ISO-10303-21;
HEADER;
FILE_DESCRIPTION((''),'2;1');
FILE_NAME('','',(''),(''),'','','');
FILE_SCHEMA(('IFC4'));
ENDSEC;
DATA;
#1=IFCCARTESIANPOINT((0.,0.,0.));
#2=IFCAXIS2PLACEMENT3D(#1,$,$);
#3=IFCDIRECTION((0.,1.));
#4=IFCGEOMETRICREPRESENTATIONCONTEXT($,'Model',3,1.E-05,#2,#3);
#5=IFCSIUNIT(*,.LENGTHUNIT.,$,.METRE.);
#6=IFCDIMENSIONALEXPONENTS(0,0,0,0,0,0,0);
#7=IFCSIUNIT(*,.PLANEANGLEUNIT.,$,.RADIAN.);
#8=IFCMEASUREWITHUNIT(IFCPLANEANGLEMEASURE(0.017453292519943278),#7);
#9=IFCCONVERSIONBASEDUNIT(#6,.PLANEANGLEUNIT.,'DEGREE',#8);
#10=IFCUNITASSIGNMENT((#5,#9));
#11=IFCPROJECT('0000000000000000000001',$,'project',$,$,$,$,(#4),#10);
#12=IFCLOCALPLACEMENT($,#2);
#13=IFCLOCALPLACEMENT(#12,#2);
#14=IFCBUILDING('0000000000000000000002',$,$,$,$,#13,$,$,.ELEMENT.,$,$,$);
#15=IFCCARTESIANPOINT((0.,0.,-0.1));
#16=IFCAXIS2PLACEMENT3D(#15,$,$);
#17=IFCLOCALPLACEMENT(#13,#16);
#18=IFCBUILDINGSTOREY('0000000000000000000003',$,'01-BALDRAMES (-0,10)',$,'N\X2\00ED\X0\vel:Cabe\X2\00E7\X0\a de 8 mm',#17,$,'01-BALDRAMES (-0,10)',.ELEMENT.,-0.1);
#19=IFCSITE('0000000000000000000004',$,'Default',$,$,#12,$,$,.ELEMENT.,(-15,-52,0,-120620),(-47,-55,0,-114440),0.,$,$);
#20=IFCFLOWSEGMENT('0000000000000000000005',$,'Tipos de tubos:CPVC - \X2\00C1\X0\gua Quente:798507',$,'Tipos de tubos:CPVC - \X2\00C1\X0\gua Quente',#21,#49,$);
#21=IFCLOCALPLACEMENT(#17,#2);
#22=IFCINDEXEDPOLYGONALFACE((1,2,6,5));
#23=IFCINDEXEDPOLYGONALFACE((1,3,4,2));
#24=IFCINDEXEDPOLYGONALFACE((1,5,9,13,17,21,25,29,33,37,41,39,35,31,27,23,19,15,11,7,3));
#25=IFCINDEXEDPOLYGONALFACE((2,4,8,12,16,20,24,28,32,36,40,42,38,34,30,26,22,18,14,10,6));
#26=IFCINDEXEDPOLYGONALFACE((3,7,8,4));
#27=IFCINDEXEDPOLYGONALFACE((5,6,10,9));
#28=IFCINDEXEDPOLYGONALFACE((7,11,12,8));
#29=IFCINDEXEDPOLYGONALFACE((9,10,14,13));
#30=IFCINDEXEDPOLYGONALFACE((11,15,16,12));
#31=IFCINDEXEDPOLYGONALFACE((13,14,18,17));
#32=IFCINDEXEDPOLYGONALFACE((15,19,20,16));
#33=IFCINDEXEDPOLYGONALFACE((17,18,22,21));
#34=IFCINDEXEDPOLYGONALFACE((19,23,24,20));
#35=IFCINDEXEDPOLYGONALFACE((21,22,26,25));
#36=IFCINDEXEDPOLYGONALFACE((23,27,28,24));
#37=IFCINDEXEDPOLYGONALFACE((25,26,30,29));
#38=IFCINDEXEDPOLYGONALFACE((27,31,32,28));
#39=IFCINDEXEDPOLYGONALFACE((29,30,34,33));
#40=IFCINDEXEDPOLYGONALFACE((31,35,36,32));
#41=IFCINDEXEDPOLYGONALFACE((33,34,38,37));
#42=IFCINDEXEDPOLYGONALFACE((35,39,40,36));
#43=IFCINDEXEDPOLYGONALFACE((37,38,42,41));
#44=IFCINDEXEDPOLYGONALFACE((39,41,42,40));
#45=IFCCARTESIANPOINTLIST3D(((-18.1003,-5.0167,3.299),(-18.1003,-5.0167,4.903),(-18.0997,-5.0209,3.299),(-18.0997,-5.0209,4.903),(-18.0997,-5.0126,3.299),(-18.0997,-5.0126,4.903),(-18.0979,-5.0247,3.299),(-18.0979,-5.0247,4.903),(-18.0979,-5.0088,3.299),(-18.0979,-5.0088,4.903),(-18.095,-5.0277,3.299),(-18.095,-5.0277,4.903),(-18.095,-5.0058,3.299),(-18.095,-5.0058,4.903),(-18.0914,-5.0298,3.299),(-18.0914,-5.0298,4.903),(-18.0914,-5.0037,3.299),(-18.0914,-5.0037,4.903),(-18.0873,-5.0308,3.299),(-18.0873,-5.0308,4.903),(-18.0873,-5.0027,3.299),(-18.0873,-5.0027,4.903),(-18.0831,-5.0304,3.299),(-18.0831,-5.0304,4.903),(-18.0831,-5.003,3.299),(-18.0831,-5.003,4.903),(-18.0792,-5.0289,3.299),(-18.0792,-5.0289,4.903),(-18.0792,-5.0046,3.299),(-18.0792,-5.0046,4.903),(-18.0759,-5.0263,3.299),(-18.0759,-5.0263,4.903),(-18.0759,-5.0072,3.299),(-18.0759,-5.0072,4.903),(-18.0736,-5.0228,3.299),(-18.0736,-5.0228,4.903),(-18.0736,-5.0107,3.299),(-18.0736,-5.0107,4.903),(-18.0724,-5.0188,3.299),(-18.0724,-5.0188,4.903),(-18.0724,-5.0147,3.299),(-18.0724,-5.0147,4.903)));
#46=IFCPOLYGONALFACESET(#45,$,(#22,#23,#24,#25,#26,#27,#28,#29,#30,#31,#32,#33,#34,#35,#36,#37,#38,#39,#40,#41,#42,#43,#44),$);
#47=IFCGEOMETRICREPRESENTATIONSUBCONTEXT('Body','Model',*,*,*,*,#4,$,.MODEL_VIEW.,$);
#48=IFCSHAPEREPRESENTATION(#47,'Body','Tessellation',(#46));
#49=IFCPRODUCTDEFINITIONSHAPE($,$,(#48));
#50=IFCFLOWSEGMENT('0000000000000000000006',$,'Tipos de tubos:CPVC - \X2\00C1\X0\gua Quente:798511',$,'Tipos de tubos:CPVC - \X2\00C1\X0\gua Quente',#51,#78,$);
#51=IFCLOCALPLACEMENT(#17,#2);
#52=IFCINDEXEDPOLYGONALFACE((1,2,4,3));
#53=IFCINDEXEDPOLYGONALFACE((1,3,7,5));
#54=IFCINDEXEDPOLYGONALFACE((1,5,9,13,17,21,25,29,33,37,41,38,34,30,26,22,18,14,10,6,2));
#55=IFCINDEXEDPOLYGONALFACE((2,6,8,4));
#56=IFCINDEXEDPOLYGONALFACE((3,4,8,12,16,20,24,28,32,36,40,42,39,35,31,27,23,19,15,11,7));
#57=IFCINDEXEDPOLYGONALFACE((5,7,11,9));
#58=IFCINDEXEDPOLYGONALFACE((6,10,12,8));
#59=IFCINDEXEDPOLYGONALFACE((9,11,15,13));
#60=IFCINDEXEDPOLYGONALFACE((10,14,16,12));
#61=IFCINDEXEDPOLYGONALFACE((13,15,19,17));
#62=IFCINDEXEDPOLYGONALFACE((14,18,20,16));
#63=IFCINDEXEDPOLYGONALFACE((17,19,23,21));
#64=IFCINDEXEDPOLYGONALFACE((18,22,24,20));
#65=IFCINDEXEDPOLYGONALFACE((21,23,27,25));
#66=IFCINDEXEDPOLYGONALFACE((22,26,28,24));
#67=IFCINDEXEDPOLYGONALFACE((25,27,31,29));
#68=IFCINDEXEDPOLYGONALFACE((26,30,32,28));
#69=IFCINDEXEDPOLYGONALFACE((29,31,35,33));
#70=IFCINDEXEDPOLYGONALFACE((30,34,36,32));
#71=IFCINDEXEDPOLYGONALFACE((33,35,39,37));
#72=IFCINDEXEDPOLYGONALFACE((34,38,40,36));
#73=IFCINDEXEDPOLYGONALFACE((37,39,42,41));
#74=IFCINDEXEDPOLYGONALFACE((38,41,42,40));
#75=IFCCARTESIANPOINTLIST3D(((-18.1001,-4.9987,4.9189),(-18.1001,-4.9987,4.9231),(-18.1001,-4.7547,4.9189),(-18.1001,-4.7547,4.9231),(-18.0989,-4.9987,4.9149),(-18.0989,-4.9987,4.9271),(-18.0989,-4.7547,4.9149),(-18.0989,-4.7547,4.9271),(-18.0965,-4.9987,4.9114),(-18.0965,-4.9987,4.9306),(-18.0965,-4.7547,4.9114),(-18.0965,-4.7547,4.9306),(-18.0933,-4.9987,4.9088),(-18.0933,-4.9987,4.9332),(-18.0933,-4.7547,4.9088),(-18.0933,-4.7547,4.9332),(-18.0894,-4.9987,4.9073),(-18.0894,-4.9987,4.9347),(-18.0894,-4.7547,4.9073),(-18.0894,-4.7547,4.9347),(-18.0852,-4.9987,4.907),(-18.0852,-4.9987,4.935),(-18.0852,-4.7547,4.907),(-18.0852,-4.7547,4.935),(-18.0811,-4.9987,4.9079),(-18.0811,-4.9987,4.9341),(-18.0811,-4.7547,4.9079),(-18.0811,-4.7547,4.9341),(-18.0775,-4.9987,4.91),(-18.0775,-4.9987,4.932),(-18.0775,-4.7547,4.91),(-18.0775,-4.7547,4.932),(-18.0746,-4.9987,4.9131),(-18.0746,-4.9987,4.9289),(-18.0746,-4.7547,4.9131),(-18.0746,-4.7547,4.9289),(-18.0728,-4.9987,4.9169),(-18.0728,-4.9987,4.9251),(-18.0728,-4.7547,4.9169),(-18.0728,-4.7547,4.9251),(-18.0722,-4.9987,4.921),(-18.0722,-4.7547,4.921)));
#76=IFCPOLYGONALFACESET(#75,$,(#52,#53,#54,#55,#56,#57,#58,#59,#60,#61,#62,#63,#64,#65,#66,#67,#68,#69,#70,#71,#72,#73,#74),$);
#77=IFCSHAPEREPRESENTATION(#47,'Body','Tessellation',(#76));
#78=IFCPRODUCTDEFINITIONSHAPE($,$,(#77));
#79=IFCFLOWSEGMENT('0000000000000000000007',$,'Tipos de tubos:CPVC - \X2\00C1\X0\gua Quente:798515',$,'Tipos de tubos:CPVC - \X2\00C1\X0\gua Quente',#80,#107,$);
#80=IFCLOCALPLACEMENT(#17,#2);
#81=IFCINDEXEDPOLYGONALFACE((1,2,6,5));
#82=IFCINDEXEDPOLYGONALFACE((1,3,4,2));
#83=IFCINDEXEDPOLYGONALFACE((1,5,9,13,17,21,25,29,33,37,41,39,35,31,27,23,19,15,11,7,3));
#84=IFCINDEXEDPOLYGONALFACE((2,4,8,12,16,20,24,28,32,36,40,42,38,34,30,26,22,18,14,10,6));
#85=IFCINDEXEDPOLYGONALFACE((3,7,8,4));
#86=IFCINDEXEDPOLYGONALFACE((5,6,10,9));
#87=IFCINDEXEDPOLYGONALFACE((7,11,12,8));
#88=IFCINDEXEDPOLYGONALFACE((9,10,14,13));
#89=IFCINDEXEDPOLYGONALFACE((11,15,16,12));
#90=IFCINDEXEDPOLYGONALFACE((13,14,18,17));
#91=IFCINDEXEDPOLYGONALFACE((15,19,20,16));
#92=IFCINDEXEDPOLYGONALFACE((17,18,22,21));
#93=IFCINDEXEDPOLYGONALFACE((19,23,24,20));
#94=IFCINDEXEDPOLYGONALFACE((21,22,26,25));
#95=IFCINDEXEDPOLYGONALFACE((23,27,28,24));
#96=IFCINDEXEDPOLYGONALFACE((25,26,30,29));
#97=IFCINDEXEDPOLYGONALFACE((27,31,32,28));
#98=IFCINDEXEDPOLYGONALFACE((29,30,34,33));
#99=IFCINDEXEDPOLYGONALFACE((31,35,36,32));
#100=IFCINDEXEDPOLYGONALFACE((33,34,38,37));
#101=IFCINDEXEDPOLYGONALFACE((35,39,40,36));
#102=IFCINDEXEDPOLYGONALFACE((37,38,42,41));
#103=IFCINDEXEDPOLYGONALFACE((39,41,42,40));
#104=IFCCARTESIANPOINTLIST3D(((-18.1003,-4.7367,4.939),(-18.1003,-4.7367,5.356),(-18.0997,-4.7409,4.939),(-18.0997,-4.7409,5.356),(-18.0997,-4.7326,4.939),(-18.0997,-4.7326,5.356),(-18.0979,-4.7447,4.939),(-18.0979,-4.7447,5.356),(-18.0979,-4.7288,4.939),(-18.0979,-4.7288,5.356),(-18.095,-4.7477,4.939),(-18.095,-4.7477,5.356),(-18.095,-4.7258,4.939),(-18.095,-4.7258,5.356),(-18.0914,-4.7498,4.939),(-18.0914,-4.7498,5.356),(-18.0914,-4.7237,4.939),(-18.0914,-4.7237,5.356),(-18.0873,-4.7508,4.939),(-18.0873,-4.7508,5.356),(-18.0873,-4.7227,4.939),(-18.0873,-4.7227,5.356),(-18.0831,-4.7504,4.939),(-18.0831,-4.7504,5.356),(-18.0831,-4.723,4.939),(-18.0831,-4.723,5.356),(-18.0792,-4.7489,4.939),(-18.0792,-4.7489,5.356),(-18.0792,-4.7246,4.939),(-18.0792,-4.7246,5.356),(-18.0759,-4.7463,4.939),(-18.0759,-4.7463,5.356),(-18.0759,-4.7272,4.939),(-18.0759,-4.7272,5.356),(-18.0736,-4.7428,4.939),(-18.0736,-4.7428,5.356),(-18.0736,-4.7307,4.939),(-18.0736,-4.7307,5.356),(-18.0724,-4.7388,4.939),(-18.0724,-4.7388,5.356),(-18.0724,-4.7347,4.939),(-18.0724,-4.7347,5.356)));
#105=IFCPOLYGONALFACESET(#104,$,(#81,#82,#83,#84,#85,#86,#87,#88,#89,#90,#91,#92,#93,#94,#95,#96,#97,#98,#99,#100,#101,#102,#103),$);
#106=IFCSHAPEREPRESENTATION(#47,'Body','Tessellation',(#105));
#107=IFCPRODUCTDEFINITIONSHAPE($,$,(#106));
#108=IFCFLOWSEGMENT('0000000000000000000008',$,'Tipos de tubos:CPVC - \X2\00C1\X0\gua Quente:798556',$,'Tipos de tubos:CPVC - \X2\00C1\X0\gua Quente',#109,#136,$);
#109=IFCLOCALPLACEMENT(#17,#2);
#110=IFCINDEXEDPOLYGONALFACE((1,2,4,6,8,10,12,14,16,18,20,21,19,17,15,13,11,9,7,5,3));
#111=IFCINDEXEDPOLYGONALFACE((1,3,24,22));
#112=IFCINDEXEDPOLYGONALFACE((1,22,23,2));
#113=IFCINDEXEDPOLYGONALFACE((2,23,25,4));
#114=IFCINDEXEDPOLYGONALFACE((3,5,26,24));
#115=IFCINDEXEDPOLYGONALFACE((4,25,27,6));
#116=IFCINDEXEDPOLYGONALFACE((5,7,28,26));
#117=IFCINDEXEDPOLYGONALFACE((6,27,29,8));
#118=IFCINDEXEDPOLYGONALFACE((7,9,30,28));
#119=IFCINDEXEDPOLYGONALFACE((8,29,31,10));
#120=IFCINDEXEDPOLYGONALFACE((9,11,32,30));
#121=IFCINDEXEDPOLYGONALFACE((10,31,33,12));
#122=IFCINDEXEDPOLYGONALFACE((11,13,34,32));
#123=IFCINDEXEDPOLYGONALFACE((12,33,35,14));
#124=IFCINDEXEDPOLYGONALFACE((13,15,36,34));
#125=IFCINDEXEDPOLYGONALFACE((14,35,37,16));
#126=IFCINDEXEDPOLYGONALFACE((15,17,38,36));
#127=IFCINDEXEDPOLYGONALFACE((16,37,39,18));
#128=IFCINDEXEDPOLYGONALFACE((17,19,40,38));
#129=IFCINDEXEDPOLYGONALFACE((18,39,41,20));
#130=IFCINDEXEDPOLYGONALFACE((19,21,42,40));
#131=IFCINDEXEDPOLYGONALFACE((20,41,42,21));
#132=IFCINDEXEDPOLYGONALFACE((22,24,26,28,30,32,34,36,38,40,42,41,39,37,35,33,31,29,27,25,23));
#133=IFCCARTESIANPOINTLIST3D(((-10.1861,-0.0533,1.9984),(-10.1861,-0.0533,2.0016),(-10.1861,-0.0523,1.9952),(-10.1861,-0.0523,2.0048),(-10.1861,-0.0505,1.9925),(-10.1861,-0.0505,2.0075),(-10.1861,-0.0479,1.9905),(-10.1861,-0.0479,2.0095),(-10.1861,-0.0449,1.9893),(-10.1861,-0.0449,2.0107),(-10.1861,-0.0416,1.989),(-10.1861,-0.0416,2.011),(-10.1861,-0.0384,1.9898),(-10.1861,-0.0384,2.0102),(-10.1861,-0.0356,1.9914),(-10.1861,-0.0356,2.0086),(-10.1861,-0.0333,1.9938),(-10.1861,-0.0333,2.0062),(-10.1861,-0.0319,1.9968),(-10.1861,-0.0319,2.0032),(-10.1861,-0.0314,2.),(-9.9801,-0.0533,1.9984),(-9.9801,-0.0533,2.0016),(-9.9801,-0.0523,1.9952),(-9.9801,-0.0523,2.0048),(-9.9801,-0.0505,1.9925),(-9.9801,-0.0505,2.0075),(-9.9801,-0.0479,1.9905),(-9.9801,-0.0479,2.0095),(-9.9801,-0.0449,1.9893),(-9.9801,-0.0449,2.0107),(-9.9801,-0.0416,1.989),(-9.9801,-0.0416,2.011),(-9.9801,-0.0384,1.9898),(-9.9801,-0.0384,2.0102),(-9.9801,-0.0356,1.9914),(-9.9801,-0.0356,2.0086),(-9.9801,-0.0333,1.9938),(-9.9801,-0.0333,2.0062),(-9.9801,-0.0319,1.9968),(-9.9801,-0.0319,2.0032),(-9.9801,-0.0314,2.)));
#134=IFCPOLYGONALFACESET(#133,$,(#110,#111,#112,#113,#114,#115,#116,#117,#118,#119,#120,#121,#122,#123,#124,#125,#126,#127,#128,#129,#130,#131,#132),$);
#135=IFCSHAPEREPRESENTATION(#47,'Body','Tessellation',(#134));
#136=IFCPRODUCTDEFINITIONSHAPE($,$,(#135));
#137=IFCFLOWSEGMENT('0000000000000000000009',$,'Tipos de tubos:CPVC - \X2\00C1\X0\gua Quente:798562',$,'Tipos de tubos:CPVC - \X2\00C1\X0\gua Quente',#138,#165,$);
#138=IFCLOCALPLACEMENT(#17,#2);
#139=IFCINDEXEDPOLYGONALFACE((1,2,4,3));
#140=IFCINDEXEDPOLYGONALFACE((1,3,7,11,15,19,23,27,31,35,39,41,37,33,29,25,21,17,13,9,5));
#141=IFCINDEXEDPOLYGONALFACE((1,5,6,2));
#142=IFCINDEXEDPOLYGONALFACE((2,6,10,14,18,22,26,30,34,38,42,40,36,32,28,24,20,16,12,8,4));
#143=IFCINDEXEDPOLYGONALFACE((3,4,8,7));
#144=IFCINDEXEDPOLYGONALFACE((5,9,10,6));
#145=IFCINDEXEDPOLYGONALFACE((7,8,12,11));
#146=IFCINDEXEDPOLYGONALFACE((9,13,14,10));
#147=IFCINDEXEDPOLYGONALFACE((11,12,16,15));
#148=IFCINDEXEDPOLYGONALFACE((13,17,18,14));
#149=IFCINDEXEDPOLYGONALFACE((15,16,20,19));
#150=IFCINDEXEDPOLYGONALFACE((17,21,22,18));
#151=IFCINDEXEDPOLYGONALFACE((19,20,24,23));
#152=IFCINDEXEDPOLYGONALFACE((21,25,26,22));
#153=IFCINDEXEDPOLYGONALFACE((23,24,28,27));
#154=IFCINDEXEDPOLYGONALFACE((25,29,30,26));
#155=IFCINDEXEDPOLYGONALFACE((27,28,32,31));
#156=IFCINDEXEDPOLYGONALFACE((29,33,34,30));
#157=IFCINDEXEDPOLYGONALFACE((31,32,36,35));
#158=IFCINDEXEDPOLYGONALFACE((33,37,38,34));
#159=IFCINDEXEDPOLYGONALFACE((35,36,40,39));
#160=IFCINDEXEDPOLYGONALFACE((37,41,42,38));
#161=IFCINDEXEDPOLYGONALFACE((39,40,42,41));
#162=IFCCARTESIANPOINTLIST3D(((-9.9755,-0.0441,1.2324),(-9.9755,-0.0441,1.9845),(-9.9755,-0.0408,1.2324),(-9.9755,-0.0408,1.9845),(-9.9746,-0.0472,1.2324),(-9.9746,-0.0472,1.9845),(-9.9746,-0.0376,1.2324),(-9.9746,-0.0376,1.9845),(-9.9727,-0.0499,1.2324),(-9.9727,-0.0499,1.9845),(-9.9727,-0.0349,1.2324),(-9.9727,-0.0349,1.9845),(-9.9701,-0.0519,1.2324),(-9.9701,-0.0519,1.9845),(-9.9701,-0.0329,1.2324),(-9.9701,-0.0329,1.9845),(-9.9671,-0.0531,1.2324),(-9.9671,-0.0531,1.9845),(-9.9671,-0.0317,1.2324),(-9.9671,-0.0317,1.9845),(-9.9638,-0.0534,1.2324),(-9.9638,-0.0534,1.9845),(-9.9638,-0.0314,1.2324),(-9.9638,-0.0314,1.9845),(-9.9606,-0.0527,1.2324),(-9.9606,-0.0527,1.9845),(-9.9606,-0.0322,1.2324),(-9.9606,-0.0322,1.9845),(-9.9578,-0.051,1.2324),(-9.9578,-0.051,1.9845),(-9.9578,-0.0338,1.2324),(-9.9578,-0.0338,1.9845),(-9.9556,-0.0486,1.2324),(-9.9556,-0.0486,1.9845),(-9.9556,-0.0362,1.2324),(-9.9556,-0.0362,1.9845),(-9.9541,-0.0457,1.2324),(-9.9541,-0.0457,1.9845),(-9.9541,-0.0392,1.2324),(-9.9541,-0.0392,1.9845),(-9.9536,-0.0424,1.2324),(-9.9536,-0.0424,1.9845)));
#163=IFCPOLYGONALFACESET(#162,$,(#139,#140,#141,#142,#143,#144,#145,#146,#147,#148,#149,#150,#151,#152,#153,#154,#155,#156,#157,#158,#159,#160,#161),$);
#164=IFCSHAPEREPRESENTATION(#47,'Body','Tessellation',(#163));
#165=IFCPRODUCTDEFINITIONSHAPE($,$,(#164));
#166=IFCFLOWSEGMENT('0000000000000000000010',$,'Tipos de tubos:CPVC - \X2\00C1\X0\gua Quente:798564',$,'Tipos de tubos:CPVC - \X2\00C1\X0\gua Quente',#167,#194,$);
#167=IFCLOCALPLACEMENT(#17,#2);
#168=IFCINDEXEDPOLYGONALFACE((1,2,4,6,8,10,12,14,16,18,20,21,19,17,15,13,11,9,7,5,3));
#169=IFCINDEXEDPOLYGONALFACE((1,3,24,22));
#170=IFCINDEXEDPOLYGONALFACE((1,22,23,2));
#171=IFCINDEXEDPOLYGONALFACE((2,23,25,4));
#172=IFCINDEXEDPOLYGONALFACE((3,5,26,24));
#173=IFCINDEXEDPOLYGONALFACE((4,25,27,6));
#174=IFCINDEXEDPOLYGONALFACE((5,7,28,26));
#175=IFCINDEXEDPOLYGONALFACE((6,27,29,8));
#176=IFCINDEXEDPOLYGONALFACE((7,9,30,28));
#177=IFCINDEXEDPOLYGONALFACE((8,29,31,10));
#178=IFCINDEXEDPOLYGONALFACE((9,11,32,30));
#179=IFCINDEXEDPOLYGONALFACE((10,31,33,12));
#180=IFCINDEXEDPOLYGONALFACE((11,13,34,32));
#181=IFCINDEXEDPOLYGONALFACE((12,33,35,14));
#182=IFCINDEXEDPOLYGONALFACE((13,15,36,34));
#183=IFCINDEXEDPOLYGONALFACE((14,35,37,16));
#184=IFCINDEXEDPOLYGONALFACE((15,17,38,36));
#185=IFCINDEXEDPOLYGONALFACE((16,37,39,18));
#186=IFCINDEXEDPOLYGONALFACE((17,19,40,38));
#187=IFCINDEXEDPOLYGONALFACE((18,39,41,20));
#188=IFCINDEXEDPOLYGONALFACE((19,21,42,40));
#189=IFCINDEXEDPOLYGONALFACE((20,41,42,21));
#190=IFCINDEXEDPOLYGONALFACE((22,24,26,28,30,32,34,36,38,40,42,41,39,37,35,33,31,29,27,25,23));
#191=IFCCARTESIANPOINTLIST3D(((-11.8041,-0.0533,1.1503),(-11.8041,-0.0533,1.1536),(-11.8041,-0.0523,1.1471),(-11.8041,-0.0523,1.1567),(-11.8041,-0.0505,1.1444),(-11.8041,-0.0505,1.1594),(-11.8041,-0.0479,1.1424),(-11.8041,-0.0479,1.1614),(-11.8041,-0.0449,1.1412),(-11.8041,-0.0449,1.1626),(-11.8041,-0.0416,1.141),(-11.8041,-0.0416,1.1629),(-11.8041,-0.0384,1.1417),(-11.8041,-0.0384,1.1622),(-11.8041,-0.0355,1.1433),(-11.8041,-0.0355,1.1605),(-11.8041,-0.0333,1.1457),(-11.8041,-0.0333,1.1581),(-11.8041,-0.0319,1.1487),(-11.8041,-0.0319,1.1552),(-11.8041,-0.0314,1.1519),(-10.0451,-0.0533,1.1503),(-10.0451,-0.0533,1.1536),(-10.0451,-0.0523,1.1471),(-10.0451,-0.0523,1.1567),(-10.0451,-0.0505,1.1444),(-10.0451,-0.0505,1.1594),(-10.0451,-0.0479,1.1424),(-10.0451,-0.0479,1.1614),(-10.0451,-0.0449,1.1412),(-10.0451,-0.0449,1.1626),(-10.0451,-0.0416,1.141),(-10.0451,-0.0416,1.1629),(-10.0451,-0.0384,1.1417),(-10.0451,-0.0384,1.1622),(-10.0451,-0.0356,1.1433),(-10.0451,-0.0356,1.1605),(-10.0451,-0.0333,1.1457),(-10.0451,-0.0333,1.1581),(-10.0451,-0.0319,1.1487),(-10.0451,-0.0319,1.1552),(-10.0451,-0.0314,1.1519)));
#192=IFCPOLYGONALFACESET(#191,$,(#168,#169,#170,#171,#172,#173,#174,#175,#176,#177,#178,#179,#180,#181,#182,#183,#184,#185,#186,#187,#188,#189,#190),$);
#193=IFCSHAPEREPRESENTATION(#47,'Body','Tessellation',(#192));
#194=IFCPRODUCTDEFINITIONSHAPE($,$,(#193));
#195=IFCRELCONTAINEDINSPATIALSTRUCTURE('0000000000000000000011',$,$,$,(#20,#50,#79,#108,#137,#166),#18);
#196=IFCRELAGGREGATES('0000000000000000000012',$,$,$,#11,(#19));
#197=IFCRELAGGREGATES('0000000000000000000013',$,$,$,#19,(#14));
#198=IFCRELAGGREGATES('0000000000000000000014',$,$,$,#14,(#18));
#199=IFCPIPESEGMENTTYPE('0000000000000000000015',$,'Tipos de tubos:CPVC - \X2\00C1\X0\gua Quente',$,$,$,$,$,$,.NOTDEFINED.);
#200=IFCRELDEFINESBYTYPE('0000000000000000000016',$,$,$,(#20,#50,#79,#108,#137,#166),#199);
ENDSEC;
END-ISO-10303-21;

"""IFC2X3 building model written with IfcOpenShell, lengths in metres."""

from ifc_helpers import new_model, entity, si_unit, converted_unit, direction, frame, frame_2d, origin, origin_2d_with_axis, place, context, subcontext, project, spatial, circle, extrude, type_object, element, save


model = new_model("IFC2X3")

# Units and contexts
model_context = context("Model", 3, precision=1e-05, world=origin(), true_north=direction((0.0, 1.0)))
body_context = subcontext(model_context, "Body", "Model", "MODEL_VIEW")
ifc_project = project(units=[si_unit("LENGTHUNIT", "METRE"), converted_unit("PLANEANGLEUNIT", "DEGREE", entity("IfcPlaneAngleMeasure", 0.017453292519943278), si_unit("PLANEANGLEUNIT", "RADIAN"), dimensions=[0, 0, 0, 0, 0, 0, 0])], contexts=[model_context])

# Site, building, storey
site_placement = place(None, origin())
site = spatial("IfcSite", under=ifc_project, at=site_placement, Name="Default", CompositionType="ELEMENT", RefLatitude=(-15, -52, 0, -120620), RefLongitude=(-47, -55, 0, -114440), RefElevation=0.0)
building_placement = place(site_placement, origin())
building = spatial("IfcBuilding", under=site, at=building_placement, CompositionType="ELEMENT")
storey_placement = place(building_placement, frame((0.0, 0.0, -0.1)))
storey = spatial("IfcBuildingStorey", under=building, at=storey_placement, Name="01-BALDRAMES (-0,10)", ObjectType="Nível:Cabeça de 8 mm", LongName="01-BALDRAMES (-0,10)", CompositionType="ELEMENT", Elevation=-0.1)

# Flow segments
pipe_segment_type_1 = type_object("IfcPipeSegmentType", Name="Tipos de tubos:CPVC - Água Quente", PredefinedType="NOTDEFINED")
flow_segment_1_placement = place(storey_placement, origin())
element("IfcFlowSegment", 1, at=flow_segment_1_placement, inside=storey, type_object=pipe_segment_type_1, Name="Tipos de tubos:CPVC - Água Quente:798507", ObjectType="Tipos de tubos:CPVC - Água Quente", context=body_context, shape_type="SweptSolid", body=[
    extrude(circle(Radius=0.0141, at=frame_2d((0.0, 0.0), x_axis=(1.0, 0.0))), frame((-18.0862, -5.0167, 3.299), z_axis=(0.0, 0.0, 1.0), x_axis=(-1.0, 0.0, 0.0)), (0.0, 0.0, 1.0), 1.604),
])
flow_segment_2_placement = place(storey_placement, origin())
element("IfcFlowSegment", 2, at=flow_segment_2_placement, inside=storey, type_object=pipe_segment_type_1, Name="Tipos de tubos:CPVC - Água Quente:798511", ObjectType="Tipos de tubos:CPVC - Água Quente", context=body_context, shape_type="SweptSolid", body=[
    extrude(circle(Radius=0.0141, at=origin_2d_with_axis()), frame((-18.0862, -4.9987, 4.921), z_axis=(0.0, 1.0, 0.0), x_axis=(1.0, 0.0, 0.0)), (0.0, 0.0, 1.0), 0.244),
])
flow_segment_3_placement = place(storey_placement, origin())
element("IfcFlowSegment", 3, at=flow_segment_3_placement, inside=storey, type_object=pipe_segment_type_1, Name="Tipos de tubos:CPVC - Água Quente:798515", ObjectType="Tipos de tubos:CPVC - Água Quente", context=body_context, shape_type="SweptSolid", body=[
    extrude(circle(Radius=0.0141, at=origin_2d_with_axis()), frame((-18.0862, -4.7367, 4.939), z_axis=(0.0, 0.0, 1.0), x_axis=(-1.0, 0.0, 0.0)), (0.0, 0.0, 1.0), 0.417),
])
flow_segment_4_placement = place(storey_placement, origin())
element("IfcFlowSegment", 4, at=flow_segment_4_placement, inside=storey, type_object=pipe_segment_type_1, Name="Tipos de tubos:CPVC - Água Quente:798556", ObjectType="Tipos de tubos:CPVC - Água Quente", context=body_context, shape_type="SweptSolid", body=[
    extrude(circle(Radius=0.011, at=frame_2d((0.0, 0.0), x_axis=(1.0, 0.0))), frame((-10.1861, -0.0424, 2.0), z_axis=(1.0, -0.000004, 0.0), x_axis=(0.000004, 1.0, 0.0)), (0.0, 0.0, 1.0), 0.206),
])
flow_segment_5_placement = place(storey_placement, origin())
element("IfcFlowSegment", 5, at=flow_segment_5_placement, inside=storey, type_object=pipe_segment_type_1, Name="Tipos de tubos:CPVC - Água Quente:798562", ObjectType="Tipos de tubos:CPVC - Água Quente", context=body_context, shape_type="SweptSolid", body=[
    extrude(circle(Radius=0.011, at=frame_2d((0.0, 0.0), x_axis=(1.0, 0.0))), frame((-9.9646, -0.0424, 1.2324)), (0.0, 0.0, 1.0), 0.7521),
])
flow_segment_6_placement = place(storey_placement, origin())
element("IfcFlowSegment", 6, at=flow_segment_6_placement, inside=storey, type_object=pipe_segment_type_1, Name="Tipos de tubos:CPVC - Água Quente:798564", ObjectType="Tipos de tubos:CPVC - Água Quente", context=body_context, shape_type="SweptSolid", body=[
    extrude(circle(Radius=0.011, at=frame_2d((0.0, 0.0), x_axis=(1.0, 0.0))), frame((-11.8041, -0.0424, 1.1519), z_axis=(1.0, -0.000004, 0.0), x_axis=(0.000004, 1.0, 0.0)), (0.0, 0.0, 1.0), 1.759),
])

save(model, "model.ifc")
